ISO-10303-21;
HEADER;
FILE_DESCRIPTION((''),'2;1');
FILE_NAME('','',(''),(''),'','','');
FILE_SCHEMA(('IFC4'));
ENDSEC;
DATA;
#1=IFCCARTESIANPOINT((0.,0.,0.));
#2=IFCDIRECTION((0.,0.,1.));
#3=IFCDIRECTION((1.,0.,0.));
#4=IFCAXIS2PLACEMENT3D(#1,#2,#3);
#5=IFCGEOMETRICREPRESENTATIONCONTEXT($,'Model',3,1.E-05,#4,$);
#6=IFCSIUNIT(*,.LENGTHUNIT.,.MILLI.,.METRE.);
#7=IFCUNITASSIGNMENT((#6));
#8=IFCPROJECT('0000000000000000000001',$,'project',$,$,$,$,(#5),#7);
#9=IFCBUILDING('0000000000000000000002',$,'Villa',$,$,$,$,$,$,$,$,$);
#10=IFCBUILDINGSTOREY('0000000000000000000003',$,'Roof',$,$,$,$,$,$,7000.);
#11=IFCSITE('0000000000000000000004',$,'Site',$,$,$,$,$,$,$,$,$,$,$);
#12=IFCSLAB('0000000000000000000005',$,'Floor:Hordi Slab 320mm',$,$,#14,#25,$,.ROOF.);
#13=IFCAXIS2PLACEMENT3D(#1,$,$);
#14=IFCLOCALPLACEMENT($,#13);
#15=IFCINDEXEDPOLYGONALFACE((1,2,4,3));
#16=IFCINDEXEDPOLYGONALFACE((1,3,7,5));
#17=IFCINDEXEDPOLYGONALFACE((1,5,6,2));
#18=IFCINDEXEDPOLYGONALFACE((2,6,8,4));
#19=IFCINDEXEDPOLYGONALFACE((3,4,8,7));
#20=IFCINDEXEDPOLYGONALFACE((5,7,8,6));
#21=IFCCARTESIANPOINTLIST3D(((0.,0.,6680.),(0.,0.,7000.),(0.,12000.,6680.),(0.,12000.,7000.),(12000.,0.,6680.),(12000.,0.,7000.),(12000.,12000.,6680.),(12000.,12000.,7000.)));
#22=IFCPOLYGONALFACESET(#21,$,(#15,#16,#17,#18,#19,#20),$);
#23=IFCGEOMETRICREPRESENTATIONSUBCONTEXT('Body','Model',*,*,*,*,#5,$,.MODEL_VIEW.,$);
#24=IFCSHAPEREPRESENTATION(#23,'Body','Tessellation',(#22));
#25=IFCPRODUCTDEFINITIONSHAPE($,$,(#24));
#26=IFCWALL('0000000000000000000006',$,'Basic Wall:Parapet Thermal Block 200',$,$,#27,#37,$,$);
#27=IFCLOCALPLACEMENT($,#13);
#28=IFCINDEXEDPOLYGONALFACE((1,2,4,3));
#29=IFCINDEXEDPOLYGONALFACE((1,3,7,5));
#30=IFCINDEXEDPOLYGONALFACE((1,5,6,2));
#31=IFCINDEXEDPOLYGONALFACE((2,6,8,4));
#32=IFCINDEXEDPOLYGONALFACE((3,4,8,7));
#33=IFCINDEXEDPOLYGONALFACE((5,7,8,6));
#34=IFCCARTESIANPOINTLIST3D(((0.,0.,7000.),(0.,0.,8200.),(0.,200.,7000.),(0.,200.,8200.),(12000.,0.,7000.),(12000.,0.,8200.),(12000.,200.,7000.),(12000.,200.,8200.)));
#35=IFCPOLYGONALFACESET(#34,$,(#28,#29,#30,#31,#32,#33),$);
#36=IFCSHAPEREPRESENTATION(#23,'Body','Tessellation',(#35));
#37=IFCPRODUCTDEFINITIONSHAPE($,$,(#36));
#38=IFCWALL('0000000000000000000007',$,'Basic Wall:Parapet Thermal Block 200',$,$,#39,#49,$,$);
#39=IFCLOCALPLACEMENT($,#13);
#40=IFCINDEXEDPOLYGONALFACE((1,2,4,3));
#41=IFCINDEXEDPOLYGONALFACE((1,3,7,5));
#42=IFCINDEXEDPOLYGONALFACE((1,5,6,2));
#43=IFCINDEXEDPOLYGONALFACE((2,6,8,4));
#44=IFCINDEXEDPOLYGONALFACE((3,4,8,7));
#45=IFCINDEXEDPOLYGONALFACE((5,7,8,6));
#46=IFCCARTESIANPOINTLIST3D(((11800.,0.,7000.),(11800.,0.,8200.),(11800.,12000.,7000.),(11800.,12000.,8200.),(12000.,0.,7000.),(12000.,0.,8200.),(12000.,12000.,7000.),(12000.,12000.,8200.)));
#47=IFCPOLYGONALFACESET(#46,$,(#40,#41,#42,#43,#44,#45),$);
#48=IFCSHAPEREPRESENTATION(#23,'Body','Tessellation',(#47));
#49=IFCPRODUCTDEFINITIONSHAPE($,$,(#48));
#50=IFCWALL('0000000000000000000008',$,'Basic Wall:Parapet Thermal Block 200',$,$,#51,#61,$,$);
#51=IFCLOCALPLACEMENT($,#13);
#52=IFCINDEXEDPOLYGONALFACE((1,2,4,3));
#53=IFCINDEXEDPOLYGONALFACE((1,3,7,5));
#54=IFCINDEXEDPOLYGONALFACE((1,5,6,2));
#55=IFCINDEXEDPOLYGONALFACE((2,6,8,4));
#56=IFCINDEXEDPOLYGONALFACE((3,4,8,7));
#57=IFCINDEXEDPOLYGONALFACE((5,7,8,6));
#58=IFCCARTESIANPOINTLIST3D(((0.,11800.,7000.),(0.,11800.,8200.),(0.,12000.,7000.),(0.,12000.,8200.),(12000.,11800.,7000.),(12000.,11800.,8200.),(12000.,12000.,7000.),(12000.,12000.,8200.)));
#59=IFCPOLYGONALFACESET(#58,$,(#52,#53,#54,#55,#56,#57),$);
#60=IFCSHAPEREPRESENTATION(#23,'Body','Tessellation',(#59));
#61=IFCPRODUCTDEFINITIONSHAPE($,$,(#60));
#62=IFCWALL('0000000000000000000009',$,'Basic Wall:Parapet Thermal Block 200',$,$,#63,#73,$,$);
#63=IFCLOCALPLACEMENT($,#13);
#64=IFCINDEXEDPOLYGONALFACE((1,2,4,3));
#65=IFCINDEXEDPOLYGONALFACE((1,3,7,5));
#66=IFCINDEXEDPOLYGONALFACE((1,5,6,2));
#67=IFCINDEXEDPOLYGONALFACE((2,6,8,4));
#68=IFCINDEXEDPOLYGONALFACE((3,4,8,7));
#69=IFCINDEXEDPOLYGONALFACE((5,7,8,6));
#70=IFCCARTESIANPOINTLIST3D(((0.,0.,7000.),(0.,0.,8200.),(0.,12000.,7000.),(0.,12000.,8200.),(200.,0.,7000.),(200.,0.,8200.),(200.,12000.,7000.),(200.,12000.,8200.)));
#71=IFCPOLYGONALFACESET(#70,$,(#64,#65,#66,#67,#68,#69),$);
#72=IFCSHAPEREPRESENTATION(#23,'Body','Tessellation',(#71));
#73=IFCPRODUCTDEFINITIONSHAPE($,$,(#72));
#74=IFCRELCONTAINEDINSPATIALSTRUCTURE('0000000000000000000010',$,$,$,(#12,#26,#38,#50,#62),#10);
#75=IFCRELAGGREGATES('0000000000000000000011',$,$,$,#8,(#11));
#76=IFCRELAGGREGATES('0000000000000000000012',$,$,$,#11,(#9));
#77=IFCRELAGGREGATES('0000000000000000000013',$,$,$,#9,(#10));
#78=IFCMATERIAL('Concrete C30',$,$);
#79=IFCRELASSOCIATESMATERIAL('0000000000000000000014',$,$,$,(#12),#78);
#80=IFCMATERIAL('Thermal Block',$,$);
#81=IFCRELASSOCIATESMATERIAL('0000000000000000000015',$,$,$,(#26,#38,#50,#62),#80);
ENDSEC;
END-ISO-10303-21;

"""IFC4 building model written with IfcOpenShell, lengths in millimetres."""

from ifc_helpers import new_model, si_unit, frame, origin_with_axes, place, context, subcontext, project, spatial, indexed_curve, outline, extrude, material, element, save


model = new_model("IFC4")

# Units and contexts
model_context = context("Model", 3, precision=1e-05, world=origin_with_axes())
body_context = subcontext(model_context, "Body", "Model", "MODEL_VIEW")
ifc_project = project(units=[si_unit("LENGTHUNIT", "METRE", prefix="MILLI")], contexts=[model_context])

# Site, building, storey
site = spatial("IfcSite", under=ifc_project, Name="Site")
building = spatial("IfcBuilding", under=site, Name="Villa")
storey = spatial("IfcBuildingStorey", under=building, Name="Roof", Elevation=7000.0)

# Slab
ifc_material_1 = material(Name="Concrete C30")
slab_placement = place(None, frame((0.0, 0.0, 6680.0), z_axis=(0.0, 0.0, 1.0), x_axis=(1.0, 0.0, 0.0)))
element("IfcSlab", 1, at=slab_placement, inside=storey, material=ifc_material_1, Name="Floor:Hordi Slab 320mm", PredefinedType="ROOF", context=body_context, shape_type="SweptSolid", body=[
    extrude(outline(indexed_curve([(0.0, 0.0), (12000.0, 0.0), (12000.0, 12000.0), (0.0, 12000.0)])), None, (0.0, 0.0, 1.0), 320.0),
])

# Walls
ifc_material_2 = material(Name="Thermal Block")
for number, where, z_axis, x_axis, name in (
    (2, (0.0, 0.0, 7000.0), (0.0, 0.0, 1.0), (1.0, 0.0, 0.0), "Basic Wall:Parapet Thermal Block 200"),
    (3, (12000.0, 0.0, 7000.0), (0.0, 0.0, 1.0), (0.0, 1.0, 0.0), "Basic Wall:Parapet Thermal Block 200"),
    (4, (12000.0, 12000.0, 7000.0), (0.0, 0.0, 1.0), (-1.0, 0.0, 0.0), "Basic Wall:Parapet Thermal Block 200"),
    (5, (0.0, 12000.0, 7000.0), (0.0, 0.0, 1.0), (0.0, -1.0, 0.0), "Basic Wall:Parapet Thermal Block 200"),
):
    element("IfcWall", number, at=place(None, frame(where, z_axis=z_axis, x_axis=x_axis)), inside=storey, material=ifc_material_2, Name=name, context=body_context, shape_type="SweptSolid", body=[
        extrude(outline(indexed_curve([(0.0, 0.0), (0.0, 200.0), (12000.0, 200.0), (12000.0, 0.0), (0.0, 0.0)], self_intersect=False)), origin_with_axes(), (0.0, 0.0, 1.0), 1200.0),
    ])

save(model, "model.ifc")
